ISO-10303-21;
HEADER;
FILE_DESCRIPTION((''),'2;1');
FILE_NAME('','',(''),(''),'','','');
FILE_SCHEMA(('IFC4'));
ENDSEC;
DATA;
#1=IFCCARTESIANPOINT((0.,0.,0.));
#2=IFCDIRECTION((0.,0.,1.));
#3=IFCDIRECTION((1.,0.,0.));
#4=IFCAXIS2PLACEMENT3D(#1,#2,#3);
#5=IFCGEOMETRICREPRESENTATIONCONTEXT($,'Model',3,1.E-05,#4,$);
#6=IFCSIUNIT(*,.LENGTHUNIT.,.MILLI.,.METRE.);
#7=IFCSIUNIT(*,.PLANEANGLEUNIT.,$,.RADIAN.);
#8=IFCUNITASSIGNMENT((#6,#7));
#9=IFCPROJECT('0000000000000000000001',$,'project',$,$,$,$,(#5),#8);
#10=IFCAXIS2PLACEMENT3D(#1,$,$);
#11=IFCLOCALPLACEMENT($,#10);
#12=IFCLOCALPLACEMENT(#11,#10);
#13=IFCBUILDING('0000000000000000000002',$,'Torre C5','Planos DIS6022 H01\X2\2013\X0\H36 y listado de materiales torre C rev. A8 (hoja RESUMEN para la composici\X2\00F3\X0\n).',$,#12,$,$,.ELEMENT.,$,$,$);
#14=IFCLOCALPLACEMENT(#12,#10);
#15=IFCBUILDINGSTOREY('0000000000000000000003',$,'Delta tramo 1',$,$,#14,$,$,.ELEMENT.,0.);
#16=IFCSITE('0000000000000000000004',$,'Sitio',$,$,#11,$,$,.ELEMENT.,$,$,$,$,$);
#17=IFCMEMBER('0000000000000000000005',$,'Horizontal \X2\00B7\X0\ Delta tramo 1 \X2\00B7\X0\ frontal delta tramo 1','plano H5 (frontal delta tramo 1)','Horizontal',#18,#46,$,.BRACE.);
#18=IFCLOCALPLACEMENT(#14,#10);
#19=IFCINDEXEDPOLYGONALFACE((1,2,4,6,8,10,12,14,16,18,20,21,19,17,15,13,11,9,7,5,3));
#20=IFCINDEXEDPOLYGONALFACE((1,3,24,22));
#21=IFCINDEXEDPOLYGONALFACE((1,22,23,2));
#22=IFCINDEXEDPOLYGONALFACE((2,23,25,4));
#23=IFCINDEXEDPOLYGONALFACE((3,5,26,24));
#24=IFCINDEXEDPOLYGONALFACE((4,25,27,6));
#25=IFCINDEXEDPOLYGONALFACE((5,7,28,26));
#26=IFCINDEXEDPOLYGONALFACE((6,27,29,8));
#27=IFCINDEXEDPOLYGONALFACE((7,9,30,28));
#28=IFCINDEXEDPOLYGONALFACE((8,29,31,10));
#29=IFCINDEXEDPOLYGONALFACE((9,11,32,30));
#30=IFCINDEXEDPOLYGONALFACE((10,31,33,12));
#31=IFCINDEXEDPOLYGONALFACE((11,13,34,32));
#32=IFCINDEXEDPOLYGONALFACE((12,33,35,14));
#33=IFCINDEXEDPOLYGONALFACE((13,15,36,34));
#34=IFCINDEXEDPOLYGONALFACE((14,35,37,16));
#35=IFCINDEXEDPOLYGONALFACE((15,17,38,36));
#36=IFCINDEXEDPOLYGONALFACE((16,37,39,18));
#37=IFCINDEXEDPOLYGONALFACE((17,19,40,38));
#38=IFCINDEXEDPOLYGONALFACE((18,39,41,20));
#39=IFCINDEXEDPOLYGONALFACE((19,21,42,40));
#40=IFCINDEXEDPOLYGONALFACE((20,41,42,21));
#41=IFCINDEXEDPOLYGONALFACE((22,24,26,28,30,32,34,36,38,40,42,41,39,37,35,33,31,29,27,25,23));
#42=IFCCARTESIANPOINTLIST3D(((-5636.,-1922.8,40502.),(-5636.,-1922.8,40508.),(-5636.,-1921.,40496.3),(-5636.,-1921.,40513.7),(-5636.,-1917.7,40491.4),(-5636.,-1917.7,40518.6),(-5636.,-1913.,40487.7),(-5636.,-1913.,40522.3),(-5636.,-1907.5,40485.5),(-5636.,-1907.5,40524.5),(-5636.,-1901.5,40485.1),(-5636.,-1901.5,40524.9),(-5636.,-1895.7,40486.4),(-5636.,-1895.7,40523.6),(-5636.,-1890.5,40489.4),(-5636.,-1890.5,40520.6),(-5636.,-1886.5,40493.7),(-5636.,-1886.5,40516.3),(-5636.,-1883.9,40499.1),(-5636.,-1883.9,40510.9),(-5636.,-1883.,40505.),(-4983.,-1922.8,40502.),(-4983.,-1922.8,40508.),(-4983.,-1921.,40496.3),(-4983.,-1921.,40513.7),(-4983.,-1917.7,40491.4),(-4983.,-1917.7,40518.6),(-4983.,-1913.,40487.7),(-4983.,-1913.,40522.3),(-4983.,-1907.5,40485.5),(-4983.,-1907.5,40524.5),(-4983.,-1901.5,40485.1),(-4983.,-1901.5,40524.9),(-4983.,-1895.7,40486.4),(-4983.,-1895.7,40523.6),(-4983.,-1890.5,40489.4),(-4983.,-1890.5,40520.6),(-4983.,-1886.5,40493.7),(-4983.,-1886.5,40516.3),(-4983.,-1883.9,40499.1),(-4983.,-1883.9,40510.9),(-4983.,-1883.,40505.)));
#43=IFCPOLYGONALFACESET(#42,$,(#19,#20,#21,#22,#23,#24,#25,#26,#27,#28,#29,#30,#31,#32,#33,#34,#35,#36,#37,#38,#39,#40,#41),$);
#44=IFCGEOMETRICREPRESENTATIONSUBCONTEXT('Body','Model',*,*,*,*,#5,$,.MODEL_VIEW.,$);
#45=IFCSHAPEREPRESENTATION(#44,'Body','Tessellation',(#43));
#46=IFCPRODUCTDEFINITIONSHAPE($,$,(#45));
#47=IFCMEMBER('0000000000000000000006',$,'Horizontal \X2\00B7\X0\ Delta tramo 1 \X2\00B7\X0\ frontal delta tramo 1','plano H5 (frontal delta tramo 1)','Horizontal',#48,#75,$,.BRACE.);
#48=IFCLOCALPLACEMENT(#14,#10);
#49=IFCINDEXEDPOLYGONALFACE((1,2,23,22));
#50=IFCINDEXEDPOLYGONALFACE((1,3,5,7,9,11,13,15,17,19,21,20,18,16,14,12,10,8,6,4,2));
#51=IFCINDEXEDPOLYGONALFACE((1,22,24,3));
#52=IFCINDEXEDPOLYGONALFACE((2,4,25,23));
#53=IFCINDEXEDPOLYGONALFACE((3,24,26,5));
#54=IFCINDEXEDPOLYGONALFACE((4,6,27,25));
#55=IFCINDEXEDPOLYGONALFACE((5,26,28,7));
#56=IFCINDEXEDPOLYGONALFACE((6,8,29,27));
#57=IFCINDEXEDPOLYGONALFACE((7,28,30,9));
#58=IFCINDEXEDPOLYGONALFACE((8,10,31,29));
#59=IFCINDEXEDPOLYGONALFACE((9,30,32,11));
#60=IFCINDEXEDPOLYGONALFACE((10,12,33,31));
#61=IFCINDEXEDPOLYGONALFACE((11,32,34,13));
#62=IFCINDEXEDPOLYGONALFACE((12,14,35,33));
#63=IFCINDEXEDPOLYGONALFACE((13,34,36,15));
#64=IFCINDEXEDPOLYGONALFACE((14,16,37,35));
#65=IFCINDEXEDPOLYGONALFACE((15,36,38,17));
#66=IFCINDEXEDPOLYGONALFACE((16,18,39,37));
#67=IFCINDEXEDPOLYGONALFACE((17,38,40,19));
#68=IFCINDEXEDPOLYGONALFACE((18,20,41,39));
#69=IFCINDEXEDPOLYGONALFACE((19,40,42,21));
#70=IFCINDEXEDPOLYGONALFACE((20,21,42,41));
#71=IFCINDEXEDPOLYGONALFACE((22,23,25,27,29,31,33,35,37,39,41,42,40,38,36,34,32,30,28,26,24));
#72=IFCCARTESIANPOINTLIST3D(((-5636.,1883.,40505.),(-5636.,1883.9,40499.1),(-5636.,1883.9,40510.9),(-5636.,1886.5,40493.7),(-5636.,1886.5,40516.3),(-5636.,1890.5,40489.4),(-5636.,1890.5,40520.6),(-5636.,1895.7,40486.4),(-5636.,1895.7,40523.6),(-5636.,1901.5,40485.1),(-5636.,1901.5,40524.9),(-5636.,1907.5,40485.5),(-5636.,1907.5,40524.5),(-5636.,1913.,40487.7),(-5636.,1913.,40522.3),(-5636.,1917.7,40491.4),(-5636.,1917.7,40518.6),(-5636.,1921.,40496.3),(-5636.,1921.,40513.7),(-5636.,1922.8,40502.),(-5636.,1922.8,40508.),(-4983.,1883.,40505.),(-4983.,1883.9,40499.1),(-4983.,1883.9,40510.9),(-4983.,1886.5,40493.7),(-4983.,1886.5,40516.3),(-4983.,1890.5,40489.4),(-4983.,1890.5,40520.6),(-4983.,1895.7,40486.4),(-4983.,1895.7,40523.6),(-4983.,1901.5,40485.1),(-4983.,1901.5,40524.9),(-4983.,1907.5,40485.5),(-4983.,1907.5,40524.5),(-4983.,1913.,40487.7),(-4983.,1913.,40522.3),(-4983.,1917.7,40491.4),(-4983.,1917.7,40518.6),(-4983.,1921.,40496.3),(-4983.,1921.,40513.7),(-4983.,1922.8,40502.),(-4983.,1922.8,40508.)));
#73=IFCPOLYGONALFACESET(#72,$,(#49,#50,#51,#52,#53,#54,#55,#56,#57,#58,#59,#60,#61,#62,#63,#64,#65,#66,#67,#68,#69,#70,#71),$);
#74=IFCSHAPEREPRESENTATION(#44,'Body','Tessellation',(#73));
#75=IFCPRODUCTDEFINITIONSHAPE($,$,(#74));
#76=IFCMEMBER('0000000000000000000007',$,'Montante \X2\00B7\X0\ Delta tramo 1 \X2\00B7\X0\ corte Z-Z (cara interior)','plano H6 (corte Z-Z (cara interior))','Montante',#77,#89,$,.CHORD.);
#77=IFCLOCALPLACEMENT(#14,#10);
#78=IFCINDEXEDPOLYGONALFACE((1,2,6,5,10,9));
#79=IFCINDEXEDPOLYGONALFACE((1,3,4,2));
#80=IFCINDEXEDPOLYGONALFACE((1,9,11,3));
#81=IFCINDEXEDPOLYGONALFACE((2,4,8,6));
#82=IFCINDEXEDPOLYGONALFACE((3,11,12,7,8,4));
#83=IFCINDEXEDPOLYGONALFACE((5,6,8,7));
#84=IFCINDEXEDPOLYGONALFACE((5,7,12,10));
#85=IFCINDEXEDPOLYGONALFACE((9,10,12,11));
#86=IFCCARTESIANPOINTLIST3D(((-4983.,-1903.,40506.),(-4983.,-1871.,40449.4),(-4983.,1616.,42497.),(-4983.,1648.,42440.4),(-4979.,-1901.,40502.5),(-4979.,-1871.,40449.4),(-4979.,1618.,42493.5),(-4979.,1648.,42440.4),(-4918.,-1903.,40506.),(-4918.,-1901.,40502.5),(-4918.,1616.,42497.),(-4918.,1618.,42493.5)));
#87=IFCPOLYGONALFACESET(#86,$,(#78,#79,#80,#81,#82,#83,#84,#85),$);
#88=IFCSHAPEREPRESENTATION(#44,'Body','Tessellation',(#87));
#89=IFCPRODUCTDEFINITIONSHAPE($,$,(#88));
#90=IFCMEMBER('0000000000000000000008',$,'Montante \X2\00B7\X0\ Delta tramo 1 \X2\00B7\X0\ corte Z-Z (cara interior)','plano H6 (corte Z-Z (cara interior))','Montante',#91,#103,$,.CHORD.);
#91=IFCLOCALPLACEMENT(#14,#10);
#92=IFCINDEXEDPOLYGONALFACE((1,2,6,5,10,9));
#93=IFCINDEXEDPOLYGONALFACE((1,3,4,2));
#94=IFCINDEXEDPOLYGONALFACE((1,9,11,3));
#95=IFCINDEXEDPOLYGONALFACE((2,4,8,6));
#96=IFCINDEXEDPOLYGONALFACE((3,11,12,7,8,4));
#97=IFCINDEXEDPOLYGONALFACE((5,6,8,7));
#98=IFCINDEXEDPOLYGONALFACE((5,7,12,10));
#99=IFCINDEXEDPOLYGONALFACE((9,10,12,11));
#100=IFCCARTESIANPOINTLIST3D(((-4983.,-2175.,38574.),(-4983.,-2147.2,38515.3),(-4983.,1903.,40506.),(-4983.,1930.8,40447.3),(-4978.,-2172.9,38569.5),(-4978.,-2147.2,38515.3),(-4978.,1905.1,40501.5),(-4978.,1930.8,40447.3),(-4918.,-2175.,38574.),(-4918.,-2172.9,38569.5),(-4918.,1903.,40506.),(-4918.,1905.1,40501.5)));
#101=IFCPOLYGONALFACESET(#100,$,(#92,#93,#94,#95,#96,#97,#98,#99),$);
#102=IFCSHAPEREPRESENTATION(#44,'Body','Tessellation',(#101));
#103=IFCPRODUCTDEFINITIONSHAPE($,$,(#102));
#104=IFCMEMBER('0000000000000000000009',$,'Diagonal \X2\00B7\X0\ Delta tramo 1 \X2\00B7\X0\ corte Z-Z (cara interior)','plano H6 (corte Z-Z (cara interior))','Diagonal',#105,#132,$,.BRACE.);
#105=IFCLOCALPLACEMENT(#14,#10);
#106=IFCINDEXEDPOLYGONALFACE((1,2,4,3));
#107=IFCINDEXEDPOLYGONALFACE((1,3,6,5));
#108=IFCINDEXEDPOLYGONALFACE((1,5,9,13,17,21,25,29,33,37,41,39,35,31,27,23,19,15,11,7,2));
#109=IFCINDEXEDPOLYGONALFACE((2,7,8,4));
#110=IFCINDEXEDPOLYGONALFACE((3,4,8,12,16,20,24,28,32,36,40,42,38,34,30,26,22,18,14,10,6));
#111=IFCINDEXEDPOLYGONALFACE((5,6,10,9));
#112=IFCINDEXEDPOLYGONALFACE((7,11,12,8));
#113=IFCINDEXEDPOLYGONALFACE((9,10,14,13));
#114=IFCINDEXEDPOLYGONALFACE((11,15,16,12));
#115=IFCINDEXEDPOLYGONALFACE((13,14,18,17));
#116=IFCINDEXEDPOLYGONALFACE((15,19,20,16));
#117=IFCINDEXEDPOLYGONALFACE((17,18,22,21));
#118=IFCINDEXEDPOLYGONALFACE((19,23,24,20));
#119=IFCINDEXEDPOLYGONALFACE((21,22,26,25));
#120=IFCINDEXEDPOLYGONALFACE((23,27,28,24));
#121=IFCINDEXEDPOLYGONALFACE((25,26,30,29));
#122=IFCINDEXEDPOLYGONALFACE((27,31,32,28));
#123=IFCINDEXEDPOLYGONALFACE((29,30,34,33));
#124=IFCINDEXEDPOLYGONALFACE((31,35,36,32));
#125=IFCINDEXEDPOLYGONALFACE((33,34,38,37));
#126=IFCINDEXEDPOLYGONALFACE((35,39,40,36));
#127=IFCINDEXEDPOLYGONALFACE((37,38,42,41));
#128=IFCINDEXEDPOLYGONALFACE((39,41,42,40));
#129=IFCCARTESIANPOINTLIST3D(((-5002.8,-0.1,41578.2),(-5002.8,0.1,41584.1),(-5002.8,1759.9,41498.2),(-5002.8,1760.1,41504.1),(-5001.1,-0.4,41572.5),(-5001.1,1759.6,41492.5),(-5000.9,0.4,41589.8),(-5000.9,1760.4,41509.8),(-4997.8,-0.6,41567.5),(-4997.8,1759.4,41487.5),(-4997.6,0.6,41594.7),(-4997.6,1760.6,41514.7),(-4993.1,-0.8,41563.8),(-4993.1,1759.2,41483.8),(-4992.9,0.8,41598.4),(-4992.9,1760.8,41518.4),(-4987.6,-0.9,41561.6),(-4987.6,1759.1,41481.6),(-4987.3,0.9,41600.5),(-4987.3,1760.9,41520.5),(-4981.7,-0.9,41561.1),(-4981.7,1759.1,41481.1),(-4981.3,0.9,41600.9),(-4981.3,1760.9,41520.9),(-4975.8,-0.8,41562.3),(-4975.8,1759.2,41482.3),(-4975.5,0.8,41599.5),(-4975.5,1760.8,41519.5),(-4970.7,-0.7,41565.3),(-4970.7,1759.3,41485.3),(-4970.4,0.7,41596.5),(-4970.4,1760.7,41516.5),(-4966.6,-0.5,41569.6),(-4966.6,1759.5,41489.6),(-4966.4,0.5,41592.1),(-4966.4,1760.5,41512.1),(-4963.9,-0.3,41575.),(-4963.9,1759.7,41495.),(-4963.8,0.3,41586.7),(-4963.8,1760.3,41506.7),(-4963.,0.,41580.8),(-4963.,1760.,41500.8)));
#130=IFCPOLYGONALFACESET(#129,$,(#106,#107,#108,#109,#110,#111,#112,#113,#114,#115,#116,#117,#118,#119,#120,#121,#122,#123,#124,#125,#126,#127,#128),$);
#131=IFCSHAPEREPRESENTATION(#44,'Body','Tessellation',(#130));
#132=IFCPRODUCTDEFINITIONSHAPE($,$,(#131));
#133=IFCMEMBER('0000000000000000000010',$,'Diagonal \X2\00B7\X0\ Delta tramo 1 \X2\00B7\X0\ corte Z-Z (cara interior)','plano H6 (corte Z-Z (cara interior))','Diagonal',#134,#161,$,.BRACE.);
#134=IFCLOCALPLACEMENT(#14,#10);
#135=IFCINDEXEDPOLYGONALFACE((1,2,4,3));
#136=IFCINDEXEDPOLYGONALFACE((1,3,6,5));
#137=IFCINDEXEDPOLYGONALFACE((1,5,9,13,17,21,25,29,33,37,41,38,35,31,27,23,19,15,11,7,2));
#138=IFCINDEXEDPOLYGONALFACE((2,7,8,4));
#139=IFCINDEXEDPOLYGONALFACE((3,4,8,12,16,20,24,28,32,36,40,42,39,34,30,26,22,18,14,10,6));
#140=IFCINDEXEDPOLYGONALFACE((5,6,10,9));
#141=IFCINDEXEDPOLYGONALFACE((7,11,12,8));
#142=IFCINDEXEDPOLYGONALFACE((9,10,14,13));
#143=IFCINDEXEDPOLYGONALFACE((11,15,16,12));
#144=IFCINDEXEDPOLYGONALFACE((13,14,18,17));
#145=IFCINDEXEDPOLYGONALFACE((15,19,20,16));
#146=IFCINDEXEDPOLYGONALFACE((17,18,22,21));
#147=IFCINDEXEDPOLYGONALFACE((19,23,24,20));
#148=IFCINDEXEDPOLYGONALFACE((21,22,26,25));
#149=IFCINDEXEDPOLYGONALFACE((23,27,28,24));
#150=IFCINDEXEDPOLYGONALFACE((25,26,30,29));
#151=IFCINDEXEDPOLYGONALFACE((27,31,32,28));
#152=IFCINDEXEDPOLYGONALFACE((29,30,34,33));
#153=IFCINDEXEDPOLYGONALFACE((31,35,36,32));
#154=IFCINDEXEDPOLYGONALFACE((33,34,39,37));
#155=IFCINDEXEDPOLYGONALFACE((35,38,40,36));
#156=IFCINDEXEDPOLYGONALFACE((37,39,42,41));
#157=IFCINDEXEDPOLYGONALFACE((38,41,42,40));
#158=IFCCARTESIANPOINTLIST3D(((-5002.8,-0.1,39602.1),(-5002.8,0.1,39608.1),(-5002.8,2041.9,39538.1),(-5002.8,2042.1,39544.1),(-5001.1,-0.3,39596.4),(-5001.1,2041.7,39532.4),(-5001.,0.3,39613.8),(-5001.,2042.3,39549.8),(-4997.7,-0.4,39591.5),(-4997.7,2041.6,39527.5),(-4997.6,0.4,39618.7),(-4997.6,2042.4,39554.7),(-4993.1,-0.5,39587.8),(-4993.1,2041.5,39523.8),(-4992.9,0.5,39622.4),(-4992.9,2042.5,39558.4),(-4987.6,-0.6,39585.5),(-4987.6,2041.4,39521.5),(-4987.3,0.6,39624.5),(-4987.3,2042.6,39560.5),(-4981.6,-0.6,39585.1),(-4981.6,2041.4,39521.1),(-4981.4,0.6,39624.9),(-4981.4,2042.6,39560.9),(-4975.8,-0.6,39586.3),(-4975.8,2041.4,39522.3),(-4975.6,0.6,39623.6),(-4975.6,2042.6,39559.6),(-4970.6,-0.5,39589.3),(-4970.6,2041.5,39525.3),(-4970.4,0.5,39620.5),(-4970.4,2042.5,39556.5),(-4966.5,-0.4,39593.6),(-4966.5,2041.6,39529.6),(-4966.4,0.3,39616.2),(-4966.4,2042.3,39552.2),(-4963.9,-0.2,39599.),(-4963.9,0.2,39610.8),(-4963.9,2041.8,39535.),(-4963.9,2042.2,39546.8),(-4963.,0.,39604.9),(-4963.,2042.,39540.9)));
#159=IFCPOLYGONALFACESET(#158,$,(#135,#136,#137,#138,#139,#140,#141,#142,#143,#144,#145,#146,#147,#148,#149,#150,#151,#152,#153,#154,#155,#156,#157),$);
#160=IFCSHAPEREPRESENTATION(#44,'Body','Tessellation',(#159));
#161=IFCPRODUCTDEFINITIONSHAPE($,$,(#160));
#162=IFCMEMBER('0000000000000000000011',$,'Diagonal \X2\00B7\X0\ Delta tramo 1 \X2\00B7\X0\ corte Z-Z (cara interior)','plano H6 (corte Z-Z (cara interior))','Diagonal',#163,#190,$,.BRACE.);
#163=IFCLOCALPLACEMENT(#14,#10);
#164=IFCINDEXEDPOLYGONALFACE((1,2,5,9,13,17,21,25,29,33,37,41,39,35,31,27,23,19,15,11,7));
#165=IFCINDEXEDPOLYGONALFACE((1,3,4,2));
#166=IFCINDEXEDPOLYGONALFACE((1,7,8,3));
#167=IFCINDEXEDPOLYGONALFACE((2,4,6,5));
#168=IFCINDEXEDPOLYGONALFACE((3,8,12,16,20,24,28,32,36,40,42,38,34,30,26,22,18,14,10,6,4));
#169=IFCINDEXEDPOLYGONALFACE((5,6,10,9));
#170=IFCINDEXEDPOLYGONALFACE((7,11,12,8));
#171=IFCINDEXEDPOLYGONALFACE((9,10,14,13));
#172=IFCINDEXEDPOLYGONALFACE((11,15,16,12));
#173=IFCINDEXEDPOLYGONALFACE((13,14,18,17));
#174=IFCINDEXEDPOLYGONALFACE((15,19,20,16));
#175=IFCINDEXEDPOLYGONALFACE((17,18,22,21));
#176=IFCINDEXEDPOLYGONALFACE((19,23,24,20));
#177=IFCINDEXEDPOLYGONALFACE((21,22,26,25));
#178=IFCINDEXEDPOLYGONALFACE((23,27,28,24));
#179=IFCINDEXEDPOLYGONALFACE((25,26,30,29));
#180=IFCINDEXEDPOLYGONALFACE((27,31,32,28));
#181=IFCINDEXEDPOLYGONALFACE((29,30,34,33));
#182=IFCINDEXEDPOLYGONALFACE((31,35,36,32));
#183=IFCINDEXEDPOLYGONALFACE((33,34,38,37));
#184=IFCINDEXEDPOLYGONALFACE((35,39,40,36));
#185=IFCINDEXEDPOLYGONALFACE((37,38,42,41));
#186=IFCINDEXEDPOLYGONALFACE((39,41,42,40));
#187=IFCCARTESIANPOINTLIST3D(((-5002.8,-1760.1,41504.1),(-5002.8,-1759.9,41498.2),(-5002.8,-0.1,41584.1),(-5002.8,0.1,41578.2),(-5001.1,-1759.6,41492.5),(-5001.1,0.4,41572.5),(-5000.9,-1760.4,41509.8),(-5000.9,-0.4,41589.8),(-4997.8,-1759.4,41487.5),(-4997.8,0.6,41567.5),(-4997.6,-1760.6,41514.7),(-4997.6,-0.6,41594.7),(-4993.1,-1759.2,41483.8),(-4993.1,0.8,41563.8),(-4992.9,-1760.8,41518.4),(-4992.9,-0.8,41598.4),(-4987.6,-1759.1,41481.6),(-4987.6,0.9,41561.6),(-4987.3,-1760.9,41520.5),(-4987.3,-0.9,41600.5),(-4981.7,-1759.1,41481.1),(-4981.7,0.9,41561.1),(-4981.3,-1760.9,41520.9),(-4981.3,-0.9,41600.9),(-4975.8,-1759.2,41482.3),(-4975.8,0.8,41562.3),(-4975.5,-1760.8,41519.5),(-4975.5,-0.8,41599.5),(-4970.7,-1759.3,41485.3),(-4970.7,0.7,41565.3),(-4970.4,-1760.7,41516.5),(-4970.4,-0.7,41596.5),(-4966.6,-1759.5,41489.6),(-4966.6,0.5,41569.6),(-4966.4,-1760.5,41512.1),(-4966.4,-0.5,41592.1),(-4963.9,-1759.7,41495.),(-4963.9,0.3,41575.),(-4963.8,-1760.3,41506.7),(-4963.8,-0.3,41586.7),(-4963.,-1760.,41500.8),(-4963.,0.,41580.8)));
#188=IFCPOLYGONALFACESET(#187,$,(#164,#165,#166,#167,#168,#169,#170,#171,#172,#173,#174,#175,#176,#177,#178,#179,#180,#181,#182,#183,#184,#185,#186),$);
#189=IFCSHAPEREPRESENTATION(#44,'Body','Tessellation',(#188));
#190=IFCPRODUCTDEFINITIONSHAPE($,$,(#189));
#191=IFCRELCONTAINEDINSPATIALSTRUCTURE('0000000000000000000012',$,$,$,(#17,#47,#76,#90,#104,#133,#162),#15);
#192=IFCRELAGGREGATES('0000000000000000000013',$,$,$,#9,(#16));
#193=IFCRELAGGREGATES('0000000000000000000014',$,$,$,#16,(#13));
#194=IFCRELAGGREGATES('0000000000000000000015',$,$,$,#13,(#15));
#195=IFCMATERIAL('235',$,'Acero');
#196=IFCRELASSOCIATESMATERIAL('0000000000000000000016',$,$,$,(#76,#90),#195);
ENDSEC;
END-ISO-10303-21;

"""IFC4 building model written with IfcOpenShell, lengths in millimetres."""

from ifc_helpers import new_model, si_unit, frame, frame_2d, origin, origin_with_axes, place, context, subcontext, project, spatial, circle, l_section, extrude, material, element, save


model = new_model("IFC4")

# Units and contexts
model_context = context("Model", 3, precision=1e-05, world=origin_with_axes())
body_context = subcontext(model_context, "Body", "Model", "MODEL_VIEW")
ifc_project = project(units=[si_unit("LENGTHUNIT", "METRE", prefix="MILLI"), si_unit("PLANEANGLEUNIT", "RADIAN")], contexts=[model_context])

# Site, building, storey
site_placement = place(None, origin())
site = spatial("IfcSite", under=ifc_project, at=site_placement, Name="Sitio", CompositionType="ELEMENT")
building_placement = place(site_placement, origin())
building = spatial("IfcBuilding", under=site, at=building_placement, Name="Torre C5", Description="Planos DIS6022 H01–H36 y listado de materiales torre C rev. A8 (hoja RESUMEN para la composición).", CompositionType="ELEMENT")
storey_placement = place(building_placement, origin())
storey = spatial("IfcBuildingStorey", under=building, at=storey_placement, Name="Delta tramo 1", CompositionType="ELEMENT", Elevation=0.0)

# Members
for number, where, z_axis, x_axis, name in (
    (1, (-5636.0, -1903.0, 40505.0), (1.0, 0.0, 0.0), (0.0, 1.0, 0.0), "Horizontal · Delta tramo 1 · frontal delta tramo 1"),
    (2, (-5636.0, 1903.0, 40505.0), (1.0, 0.0, 0.0), (0.0, -1.0, 0.0), "Horizontal · Delta tramo 1 · frontal delta tramo 1"),
):
    element("IfcMember", number, at=place(storey_placement, frame(where, z_axis=z_axis, x_axis=x_axis)), inside=storey, Name=name, Description="plano H5 (frontal delta tramo 1)", ObjectType="Horizontal", PredefinedType="BRACE", context=body_context, shape_type="SweptSolid", body=[
        extrude(circle(Radius=20.0), None, (0.0, 0.0, 1.0), 653.0),
    ])
ifc_material_1 = material(Name="235", Category="Acero")
member_1_placement = place(storey_placement, frame((-4983.0, -1903.0, 40506.0), z_axis=(0.0, 0.870351, 0.492432), x_axis=(1.0, 0.0, 0.0)))
element("IfcMember", 3, at=member_1_placement, inside=storey, material=ifc_material_1, Name="Montante · Delta tramo 1 · corte Z-Z (cara interior)", Description="plano H6 (corte Z-Z (cara interior))", ObjectType="Montante", PredefinedType="CHORD", context=body_context, shape_type="SweptSolid", body=[
    extrude(l_section(Depth=65.0, Width=65.0, Thickness=4.0, at=frame_2d((32.5, 32.5))), None, (0.0, 0.0, 1.0), 4043.2),
])
member_2_placement = place(storey_placement, frame((-4983.0, 1903.0, 40506.0), z_axis=(0.0, -0.903711, -0.428144), x_axis=(0.0, 0.428144, -0.903711)))
element("IfcMember", 4, at=member_2_placement, inside=storey, material=ifc_material_1, Name="Montante · Delta tramo 1 · corte Z-Z (cara interior)", Description="plano H6 (corte Z-Z (cara interior))", ObjectType="Montante", PredefinedType="CHORD", context=body_context, shape_type="SweptSolid", body=[
    extrude(l_section(Depth=65.0, Width=65.0, Thickness=5.0, at=frame_2d((32.5, 32.5))), None, (0.0, 0.0, 1.0), 4512.5),
])
member_3_placement = place(storey_placement, frame((-4983.0, 1760.0, 41501.0), z_axis=(0.0, -0.998969, 0.045408), x_axis=(0.999968, -0.000364, -0.00801)))
element("IfcMember", 5, at=member_3_placement, inside=storey, Name="Diagonal · Delta tramo 1 · corte Z-Z (cara interior)", Description="plano H6 (corte Z-Z (cara interior))", ObjectType="Diagonal", PredefinedType="BRACE", context=body_context, shape_type="SweptSolid", body=[
    extrude(circle(Radius=20.0), None, (0.0, 0.0, 1.0), 1761.8),
])
member_4_placement = place(storey_placement, frame((-4983.0, 2042.0, 39541.0), z_axis=(0.0, -0.999509, 0.031326), x_axis=(0.999979, -0.000201, -0.006415)))
element("IfcMember", 6, at=member_4_placement, inside=storey, Name="Diagonal · Delta tramo 1 · corte Z-Z (cara interior)", Description="plano H6 (corte Z-Z (cara interior))", ObjectType="Diagonal", PredefinedType="BRACE", context=body_context, shape_type="SweptSolid", body=[
    extrude(circle(Radius=20.0), None, (0.0, 0.0, 1.0), 2043.0),
])
member_5_placement = place(storey_placement, frame((-4983.0, -1760.0, 41501.0), z_axis=(0.0, 0.998969, 0.045408), x_axis=(0.999968, 0.000364, -0.00801)))
element("IfcMember", 7, at=member_5_placement, inside=storey, Name="Diagonal · Delta tramo 1 · corte Z-Z (cara interior)", Description="plano H6 (corte Z-Z (cara interior))", ObjectType="Diagonal", PredefinedType="BRACE", context=body_context, shape_type="SweptSolid", body=[
    extrude(circle(Radius=20.0), None, (0.0, 0.0, 1.0), 1761.8),
])

save(model, "model.ifc")
